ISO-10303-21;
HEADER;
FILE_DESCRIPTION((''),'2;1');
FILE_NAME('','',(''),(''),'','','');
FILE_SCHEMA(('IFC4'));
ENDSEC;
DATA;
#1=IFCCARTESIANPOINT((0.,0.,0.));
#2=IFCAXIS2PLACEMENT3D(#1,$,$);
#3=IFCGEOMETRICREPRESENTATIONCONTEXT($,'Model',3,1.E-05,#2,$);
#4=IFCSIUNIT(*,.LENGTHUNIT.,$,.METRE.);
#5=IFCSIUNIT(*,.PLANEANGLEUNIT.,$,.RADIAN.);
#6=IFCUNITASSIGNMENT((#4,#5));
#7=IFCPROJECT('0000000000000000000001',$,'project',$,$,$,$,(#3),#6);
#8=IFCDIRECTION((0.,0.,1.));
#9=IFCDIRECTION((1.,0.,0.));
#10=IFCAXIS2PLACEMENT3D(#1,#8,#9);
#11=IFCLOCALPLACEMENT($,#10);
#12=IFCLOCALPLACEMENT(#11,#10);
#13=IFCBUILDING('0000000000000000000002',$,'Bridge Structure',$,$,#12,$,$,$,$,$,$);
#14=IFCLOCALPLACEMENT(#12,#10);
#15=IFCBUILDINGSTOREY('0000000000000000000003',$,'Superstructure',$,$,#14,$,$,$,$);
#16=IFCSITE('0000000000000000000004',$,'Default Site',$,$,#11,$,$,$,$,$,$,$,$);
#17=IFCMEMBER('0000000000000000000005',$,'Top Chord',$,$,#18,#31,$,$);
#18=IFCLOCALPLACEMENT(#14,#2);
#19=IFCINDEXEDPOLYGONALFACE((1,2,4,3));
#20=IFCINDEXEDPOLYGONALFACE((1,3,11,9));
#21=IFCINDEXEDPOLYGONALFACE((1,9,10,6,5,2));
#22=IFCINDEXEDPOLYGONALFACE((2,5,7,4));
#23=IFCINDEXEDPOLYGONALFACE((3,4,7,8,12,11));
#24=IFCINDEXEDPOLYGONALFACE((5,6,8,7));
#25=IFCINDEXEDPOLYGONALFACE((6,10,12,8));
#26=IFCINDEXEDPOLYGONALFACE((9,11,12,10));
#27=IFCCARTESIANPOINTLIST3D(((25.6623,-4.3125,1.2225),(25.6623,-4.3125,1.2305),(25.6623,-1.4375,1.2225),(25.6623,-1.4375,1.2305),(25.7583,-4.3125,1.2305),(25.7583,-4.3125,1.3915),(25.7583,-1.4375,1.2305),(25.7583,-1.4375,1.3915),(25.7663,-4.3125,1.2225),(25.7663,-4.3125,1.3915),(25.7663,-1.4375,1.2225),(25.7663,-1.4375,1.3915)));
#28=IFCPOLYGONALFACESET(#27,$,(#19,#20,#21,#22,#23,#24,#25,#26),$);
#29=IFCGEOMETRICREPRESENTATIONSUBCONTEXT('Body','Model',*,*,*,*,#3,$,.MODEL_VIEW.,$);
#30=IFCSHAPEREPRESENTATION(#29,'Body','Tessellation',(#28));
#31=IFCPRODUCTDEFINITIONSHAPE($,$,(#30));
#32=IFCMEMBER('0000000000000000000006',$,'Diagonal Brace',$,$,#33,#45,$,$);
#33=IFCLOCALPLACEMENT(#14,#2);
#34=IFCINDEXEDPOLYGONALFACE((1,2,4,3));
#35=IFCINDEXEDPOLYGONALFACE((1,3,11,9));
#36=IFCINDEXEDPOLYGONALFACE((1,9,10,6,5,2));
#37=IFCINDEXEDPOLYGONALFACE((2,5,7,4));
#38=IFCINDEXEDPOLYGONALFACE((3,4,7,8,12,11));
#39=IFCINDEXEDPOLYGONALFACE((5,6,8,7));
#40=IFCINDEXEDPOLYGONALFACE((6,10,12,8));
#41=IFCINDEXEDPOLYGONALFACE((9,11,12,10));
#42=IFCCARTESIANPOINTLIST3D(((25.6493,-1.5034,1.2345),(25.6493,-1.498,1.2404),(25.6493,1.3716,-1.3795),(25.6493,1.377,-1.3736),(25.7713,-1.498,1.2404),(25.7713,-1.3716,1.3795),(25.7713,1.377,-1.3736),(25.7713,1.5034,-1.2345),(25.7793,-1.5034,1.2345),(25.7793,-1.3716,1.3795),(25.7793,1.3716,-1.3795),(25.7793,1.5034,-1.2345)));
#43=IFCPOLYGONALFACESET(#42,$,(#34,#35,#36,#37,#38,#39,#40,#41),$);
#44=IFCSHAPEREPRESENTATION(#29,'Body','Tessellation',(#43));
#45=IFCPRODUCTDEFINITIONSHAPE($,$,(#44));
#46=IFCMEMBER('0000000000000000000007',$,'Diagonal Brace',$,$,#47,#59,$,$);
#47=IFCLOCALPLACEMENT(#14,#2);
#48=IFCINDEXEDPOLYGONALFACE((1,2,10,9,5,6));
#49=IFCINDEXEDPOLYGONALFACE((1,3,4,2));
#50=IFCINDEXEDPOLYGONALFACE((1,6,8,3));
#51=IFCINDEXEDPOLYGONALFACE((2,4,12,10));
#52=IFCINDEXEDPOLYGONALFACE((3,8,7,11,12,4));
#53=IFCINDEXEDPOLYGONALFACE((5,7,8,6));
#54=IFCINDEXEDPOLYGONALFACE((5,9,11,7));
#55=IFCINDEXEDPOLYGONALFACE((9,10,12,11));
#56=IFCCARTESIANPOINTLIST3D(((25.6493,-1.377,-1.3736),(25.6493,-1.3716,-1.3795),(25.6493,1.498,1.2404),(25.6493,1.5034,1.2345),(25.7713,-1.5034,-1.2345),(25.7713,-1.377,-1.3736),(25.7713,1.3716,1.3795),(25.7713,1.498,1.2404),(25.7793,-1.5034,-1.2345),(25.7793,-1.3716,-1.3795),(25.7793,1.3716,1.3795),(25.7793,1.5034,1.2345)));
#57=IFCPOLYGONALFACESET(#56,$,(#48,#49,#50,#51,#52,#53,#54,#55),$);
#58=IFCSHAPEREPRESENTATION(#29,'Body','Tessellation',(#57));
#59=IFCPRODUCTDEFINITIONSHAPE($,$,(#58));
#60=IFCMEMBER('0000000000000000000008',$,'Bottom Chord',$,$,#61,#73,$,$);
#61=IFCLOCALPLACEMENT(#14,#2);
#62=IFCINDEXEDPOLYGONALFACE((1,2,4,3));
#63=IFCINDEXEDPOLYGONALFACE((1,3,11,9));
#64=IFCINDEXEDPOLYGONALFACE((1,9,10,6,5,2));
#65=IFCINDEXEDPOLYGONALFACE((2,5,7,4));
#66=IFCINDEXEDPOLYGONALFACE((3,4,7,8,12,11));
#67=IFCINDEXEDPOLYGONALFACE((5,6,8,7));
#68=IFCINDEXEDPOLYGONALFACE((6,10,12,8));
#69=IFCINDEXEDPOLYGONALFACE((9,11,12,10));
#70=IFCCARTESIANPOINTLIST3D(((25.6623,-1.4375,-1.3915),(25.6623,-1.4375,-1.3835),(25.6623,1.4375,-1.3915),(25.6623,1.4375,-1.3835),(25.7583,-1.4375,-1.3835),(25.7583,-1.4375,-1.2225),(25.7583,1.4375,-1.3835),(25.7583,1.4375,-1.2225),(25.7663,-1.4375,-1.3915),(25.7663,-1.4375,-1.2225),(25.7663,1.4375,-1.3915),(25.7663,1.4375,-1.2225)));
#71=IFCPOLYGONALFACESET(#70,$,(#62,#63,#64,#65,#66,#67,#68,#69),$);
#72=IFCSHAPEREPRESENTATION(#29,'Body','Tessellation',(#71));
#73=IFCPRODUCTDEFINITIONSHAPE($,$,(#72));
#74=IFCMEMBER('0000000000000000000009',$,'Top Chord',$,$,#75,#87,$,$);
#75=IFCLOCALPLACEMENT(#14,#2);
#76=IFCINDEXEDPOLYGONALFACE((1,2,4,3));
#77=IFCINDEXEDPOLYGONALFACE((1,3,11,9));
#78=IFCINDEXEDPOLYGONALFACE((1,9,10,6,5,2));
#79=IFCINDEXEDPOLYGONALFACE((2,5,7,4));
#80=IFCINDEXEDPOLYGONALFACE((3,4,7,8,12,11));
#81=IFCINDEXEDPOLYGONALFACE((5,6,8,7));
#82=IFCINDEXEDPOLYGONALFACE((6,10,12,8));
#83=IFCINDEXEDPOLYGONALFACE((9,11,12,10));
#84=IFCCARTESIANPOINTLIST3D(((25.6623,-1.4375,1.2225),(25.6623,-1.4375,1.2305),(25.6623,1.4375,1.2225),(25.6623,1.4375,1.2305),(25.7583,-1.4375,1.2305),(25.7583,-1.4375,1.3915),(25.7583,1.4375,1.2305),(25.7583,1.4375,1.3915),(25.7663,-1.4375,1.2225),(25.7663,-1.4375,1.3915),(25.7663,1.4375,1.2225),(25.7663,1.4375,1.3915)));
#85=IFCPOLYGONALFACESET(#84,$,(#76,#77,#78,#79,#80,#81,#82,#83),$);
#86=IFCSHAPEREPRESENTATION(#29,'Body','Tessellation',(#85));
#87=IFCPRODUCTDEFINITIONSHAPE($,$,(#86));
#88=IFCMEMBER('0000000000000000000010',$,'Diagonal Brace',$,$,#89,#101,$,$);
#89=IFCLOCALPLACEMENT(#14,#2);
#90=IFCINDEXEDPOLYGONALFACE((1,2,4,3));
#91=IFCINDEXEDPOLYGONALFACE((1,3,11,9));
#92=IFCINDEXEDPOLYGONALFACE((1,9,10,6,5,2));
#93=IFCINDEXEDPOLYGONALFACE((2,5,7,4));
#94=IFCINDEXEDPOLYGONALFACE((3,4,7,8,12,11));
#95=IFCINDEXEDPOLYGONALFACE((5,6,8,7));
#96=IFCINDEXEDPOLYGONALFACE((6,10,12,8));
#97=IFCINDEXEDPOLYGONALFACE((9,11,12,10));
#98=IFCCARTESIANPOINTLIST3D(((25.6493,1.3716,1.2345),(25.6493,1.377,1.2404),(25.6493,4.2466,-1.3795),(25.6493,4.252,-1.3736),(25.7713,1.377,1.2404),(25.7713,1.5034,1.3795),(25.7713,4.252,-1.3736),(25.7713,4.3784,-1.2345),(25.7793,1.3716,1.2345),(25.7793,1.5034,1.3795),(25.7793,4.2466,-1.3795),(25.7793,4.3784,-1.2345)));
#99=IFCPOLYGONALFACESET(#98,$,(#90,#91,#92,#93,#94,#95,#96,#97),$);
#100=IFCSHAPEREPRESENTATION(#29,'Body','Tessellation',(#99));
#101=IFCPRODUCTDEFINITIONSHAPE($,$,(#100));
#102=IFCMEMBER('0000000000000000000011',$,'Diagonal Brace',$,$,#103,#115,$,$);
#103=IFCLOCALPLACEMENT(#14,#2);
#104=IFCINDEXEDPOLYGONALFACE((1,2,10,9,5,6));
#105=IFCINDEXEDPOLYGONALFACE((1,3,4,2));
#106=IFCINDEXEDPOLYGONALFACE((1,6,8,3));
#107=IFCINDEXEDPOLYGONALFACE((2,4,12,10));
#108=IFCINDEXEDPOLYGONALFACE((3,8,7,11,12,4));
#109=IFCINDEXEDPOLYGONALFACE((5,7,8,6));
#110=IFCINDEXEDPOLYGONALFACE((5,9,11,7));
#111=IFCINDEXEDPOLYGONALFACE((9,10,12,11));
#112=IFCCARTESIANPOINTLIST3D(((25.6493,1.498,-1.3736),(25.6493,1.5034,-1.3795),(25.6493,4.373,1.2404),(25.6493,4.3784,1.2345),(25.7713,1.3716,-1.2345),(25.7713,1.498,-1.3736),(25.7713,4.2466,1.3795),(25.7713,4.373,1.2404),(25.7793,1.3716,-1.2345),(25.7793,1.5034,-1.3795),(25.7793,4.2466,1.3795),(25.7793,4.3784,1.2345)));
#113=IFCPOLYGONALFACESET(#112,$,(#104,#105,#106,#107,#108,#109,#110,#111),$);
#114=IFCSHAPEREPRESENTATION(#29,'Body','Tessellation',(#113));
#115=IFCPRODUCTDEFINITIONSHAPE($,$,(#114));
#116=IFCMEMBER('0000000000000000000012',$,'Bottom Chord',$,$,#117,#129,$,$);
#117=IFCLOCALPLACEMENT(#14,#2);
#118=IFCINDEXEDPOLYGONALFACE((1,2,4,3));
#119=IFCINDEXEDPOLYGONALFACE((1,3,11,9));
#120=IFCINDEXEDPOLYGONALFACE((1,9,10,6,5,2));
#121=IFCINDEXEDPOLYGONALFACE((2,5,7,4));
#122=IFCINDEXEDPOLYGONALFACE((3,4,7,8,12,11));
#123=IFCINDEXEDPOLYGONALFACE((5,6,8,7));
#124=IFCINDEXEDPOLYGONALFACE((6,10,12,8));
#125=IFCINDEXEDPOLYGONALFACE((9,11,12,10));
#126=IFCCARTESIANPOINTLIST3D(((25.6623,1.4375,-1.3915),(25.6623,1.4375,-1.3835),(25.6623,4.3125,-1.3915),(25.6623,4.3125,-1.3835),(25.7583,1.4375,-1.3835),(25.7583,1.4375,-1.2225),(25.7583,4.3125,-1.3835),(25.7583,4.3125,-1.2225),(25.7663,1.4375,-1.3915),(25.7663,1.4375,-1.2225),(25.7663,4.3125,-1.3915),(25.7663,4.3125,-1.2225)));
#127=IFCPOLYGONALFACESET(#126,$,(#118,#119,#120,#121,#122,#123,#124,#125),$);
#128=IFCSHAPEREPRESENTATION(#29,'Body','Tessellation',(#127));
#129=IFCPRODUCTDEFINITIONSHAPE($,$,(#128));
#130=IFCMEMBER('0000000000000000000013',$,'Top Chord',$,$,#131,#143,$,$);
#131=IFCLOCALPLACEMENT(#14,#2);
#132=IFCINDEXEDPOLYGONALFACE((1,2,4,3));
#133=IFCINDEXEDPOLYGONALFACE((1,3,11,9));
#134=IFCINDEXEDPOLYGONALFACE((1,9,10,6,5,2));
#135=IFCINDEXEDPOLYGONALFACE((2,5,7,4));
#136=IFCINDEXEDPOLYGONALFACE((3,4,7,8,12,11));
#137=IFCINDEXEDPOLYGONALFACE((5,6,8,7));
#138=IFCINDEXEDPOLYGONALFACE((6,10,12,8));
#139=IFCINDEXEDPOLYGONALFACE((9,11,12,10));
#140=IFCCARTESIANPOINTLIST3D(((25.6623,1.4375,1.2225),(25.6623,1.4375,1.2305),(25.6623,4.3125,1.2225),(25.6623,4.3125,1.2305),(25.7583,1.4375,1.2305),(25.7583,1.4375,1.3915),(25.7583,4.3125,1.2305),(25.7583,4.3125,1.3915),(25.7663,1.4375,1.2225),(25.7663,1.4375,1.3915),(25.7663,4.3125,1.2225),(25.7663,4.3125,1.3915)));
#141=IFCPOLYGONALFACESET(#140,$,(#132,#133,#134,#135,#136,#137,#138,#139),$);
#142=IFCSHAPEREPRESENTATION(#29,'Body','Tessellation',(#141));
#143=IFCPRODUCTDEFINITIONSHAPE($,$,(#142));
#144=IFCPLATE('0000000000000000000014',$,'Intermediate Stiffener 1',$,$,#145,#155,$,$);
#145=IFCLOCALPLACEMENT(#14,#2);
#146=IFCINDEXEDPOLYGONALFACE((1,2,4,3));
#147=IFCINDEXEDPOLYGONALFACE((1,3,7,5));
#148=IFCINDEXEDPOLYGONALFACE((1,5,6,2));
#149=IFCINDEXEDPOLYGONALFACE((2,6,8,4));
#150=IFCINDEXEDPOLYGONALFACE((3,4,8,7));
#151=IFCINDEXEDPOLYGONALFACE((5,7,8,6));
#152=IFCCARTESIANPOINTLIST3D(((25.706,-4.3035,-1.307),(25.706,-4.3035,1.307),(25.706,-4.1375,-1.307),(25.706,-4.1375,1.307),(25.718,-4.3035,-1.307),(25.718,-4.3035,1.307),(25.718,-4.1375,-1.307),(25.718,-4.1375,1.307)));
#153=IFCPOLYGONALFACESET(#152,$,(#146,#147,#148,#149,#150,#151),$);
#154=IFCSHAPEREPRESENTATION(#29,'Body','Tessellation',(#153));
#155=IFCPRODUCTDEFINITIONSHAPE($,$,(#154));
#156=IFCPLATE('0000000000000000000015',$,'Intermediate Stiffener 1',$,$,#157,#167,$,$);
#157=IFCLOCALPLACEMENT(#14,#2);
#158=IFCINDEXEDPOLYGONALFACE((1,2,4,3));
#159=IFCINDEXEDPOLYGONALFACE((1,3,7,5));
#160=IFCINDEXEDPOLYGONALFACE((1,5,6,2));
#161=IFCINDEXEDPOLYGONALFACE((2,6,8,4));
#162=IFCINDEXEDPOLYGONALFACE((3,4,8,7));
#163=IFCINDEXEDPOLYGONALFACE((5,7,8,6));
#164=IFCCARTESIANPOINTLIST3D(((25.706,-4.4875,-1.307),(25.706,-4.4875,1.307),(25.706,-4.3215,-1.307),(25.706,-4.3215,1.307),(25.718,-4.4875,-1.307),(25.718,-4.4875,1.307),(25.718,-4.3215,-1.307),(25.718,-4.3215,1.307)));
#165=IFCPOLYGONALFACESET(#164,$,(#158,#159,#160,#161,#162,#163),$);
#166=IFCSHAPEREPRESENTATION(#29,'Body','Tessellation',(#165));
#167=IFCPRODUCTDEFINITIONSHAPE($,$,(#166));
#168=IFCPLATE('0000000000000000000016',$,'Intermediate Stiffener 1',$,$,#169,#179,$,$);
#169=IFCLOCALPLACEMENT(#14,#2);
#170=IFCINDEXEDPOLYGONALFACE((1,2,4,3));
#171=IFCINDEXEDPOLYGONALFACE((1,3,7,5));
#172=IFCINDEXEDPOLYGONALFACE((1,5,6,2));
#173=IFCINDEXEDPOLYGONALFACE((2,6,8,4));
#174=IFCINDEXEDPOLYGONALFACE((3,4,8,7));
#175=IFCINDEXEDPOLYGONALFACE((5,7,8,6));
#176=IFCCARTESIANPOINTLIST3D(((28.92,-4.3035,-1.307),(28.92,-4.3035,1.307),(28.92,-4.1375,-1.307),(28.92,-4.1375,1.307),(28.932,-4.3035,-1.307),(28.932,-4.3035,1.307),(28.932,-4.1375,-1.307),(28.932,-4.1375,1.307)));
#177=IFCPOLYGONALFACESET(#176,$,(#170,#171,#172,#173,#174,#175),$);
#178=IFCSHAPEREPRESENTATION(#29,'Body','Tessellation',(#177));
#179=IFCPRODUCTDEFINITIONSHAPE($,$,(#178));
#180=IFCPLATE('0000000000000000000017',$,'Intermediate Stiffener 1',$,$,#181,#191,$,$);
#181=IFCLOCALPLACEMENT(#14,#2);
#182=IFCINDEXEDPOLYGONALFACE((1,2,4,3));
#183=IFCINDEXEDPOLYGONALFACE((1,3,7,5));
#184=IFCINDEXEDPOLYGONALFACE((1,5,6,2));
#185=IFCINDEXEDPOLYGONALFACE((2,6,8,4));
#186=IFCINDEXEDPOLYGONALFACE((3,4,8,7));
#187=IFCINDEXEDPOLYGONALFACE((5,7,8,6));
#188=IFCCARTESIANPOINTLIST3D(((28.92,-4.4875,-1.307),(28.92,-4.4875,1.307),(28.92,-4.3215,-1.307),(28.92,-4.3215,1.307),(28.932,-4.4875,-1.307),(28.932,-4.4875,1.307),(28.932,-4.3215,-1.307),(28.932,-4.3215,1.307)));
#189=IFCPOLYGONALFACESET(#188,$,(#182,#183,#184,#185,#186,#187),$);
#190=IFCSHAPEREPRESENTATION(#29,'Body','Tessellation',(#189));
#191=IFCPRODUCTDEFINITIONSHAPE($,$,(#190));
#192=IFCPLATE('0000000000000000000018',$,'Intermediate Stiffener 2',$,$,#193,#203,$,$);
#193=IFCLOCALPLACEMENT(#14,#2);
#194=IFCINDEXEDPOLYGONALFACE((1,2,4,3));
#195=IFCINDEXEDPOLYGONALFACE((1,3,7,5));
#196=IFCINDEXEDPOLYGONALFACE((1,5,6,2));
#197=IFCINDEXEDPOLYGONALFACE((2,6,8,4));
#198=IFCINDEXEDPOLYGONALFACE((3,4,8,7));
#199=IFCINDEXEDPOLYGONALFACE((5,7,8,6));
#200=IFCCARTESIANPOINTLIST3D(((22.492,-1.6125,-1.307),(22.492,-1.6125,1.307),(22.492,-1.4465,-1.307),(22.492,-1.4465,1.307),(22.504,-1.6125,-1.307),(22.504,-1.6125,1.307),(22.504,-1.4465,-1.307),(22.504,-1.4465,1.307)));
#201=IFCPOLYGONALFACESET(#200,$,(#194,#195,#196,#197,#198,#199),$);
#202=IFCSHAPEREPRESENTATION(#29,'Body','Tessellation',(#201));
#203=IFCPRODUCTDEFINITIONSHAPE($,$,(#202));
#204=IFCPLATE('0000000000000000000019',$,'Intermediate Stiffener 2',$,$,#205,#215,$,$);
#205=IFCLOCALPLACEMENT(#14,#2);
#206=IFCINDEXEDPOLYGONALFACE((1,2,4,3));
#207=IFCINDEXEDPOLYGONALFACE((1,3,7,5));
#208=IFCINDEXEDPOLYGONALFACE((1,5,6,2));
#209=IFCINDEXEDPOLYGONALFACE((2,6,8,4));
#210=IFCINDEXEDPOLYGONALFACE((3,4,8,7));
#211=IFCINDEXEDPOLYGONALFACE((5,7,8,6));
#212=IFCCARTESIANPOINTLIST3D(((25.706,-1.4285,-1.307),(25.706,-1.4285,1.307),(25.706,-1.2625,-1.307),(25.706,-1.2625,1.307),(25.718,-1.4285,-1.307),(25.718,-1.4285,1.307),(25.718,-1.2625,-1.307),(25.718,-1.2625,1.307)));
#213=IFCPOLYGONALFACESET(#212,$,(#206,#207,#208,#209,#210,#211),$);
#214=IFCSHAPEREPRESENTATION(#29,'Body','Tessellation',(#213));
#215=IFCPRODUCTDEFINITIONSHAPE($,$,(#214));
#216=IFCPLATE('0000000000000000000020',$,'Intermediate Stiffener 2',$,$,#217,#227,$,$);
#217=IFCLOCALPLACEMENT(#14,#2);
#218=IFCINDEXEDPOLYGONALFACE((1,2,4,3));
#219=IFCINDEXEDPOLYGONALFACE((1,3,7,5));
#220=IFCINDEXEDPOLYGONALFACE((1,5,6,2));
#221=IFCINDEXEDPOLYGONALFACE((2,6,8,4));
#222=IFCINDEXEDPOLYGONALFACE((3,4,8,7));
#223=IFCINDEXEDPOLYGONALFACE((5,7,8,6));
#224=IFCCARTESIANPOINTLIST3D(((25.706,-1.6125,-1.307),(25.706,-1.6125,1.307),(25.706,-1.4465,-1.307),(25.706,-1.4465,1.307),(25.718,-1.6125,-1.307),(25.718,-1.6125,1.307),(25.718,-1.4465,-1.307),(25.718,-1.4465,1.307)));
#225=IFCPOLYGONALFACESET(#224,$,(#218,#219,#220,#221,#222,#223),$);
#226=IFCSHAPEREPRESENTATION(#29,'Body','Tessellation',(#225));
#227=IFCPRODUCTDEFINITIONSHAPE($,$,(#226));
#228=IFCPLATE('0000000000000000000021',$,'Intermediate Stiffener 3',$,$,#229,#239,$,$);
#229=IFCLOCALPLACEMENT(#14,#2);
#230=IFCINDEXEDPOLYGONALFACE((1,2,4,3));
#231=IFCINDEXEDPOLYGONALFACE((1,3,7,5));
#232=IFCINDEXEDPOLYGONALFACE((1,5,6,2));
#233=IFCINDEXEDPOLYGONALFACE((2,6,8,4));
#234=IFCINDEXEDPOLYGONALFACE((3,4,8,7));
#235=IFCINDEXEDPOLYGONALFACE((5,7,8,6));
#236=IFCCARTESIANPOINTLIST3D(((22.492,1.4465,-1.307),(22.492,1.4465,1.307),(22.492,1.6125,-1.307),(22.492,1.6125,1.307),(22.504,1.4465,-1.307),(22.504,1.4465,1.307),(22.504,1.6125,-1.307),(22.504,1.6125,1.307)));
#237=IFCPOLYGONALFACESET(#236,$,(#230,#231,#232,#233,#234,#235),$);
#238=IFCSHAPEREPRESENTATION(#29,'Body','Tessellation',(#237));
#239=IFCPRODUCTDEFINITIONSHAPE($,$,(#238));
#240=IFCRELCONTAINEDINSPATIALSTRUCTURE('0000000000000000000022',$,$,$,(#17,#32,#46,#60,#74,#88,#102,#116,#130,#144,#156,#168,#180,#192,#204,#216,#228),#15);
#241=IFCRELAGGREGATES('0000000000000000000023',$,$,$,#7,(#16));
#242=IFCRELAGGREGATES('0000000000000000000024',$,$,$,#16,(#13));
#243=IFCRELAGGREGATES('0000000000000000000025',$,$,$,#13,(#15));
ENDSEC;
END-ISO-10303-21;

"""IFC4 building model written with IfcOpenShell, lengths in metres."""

from ifc_helpers import new_model, si_unit, frame, origin, origin_with_axes, origin_2d_with_axis, place, context, subcontext, project, spatial, rectangle, l_section, extrude, element, save


model = new_model("IFC4")

# Units and contexts
model_context = context("Model", 3, precision=1e-05, world=origin())
body_context = subcontext(model_context, "Body", "Model", "MODEL_VIEW")
ifc_project = project(units=[si_unit("LENGTHUNIT", "METRE"), si_unit("PLANEANGLEUNIT", "RADIAN")], contexts=[model_context])

# Site, building, storey
site_placement = place(None, origin_with_axes())
site = spatial("IfcSite", under=ifc_project, at=site_placement, Name="Default Site")
building_placement = place(site_placement, origin_with_axes())
building = spatial("IfcBuilding", under=site, at=building_placement, Name="Bridge Structure")
storey_placement = place(building_placement, origin_with_axes())
storey = spatial("IfcBuildingStorey", under=building, at=storey_placement, Name="Superstructure")

# Members
for number, where, z_axis, x_axis, name in (
    (1, (25.7143, -4.3125, 1.307), (0.0, 1.0, 0.0), (-1.0, 0.0, 0.0), "Top Chord"),
):
    element("IfcMember", number, at=place(storey_placement, frame(where, z_axis=z_axis, x_axis=x_axis)), inside=storey, Name=name, context=body_context, shape_type="SweptSolid", body=[
        extrude(l_section(Depth=0.169, Width=0.104, Thickness=0.008, at=origin_2d_with_axis()), origin_with_axes(), (0.0, 0.0, 1.0), 2.875),
    ])
for number, where, z_axis, x_axis, name in (
    (2, (25.7143, -1.4375, 1.307), (0.0, 0.739893, -0.672724), (-1.0, 0.0, 0.0), "Diagonal Brace"),
    (3, (25.7143, -1.4375, -1.307), (0.0, 0.739893, 0.672724), (-1.0, 0.0, 0.0), "Diagonal Brace"),
):
    element("IfcMember", number, at=place(storey_placement, frame(where, z_axis=z_axis, x_axis=x_axis)), inside=storey, Name=name, context=body_context, shape_type="SweptSolid", body=[
        extrude(l_section(Depth=0.196, Width=0.13, Thickness=0.008, at=origin_2d_with_axis()), origin_with_axes(), (0.0, 0.0, 1.0), 3.8857),
    ])
for number, where, z_axis, x_axis, name in (
    (4, (25.7143, -1.4375, -1.307), (0.0, 1.0, 0.0), (-1.0, 0.0, 0.0), "Bottom Chord"),
    (5, (25.7143, -1.4375, 1.307), (0.0, 1.0, 0.0), (-1.0, 0.0, 0.0), "Top Chord"),
):
    element("IfcMember", number, at=place(storey_placement, frame(where, z_axis=z_axis, x_axis=x_axis)), inside=storey, Name=name, context=body_context, shape_type="SweptSolid", body=[
        extrude(l_section(Depth=0.169, Width=0.104, Thickness=0.008, at=origin_2d_with_axis()), origin_with_axes(), (0.0, 0.0, 1.0), 2.875),
    ])
for number, where, z_axis, x_axis, name in (
    (6, (25.7143, 1.4375, 1.307), (0.0, 0.739893, -0.672724), (-1.0, 0.0, 0.0), "Diagonal Brace"),
    (7, (25.7143, 1.4375, -1.307), (0.0, 0.739893, 0.672724), (-1.0, 0.0, 0.0), "Diagonal Brace"),
):
    element("IfcMember", number, at=place(storey_placement, frame(where, z_axis=z_axis, x_axis=x_axis)), inside=storey, Name=name, context=body_context, shape_type="SweptSolid", body=[
        extrude(l_section(Depth=0.196, Width=0.13, Thickness=0.008, at=origin_2d_with_axis()), origin_with_axes(), (0.0, 0.0, 1.0), 3.8857),
    ])
for number, where, z_axis, x_axis, name in (
    (8, (25.7143, 1.4375, -1.307), (0.0, 1.0, 0.0), (-1.0, 0.0, 0.0), "Bottom Chord"),
    (9, (25.7143, 1.4375, 1.307), (0.0, 1.0, 0.0), (-1.0, 0.0, 0.0), "Top Chord"),
):
    element("IfcMember", number, at=place(storey_placement, frame(where, z_axis=z_axis, x_axis=x_axis)), inside=storey, Name=name, context=body_context, shape_type="SweptSolid", body=[
        extrude(l_section(Depth=0.169, Width=0.104, Thickness=0.008, at=origin_2d_with_axis()), origin_with_axes(), (0.0, 0.0, 1.0), 2.875),
    ])

# Plates
for number, where, z_axis, x_axis, name in (
    (10, (25.712, -4.2205, -1.307), (0.0, 0.0, 1.0), (1.0, 0.0, 0.0), "Intermediate Stiffener 1"),
    (11, (25.712, -4.4045, -1.307), (0.0, 0.0, 1.0), (1.0, 0.0, 0.0), "Intermediate Stiffener 1"),
    (12, (28.926, -4.2205, -1.307), (0.0, 0.0, 1.0), (1.0, 0.0, 0.0), "Intermediate Stiffener 1"),
    (13, (28.926, -4.4045, -1.307), (0.0, 0.0, 1.0), (1.0, 0.0, 0.0), "Intermediate Stiffener 1"),
    (14, (22.498, -1.5295, -1.307), (0.0, 0.0, 1.0), (1.0, 0.0, 0.0), "Intermediate Stiffener 2"),
    (15, (25.712, -1.3455, -1.307), (0.0, 0.0, 1.0), (1.0, 0.0, 0.0), "Intermediate Stiffener 2"),
    (16, (25.712, -1.5295, -1.307), (0.0, 0.0, 1.0), (1.0, 0.0, 0.0), "Intermediate Stiffener 2"),
    (17, (22.498, 1.5295, -1.307), (0.0, 0.0, 1.0), (1.0, 0.0, 0.0), "Intermediate Stiffener 3"),
):
    element("IfcPlate", number, at=place(storey_placement, frame(where, z_axis=z_axis, x_axis=x_axis)), inside=storey, Name=name, context=body_context, shape_type="SweptSolid", body=[
        extrude(rectangle(XDim=0.012, YDim=0.166, at=origin_2d_with_axis()), origin_with_axes(), (0.0, 0.0, 1.0), 2.614),
    ])

save(model, "model.ifc")
